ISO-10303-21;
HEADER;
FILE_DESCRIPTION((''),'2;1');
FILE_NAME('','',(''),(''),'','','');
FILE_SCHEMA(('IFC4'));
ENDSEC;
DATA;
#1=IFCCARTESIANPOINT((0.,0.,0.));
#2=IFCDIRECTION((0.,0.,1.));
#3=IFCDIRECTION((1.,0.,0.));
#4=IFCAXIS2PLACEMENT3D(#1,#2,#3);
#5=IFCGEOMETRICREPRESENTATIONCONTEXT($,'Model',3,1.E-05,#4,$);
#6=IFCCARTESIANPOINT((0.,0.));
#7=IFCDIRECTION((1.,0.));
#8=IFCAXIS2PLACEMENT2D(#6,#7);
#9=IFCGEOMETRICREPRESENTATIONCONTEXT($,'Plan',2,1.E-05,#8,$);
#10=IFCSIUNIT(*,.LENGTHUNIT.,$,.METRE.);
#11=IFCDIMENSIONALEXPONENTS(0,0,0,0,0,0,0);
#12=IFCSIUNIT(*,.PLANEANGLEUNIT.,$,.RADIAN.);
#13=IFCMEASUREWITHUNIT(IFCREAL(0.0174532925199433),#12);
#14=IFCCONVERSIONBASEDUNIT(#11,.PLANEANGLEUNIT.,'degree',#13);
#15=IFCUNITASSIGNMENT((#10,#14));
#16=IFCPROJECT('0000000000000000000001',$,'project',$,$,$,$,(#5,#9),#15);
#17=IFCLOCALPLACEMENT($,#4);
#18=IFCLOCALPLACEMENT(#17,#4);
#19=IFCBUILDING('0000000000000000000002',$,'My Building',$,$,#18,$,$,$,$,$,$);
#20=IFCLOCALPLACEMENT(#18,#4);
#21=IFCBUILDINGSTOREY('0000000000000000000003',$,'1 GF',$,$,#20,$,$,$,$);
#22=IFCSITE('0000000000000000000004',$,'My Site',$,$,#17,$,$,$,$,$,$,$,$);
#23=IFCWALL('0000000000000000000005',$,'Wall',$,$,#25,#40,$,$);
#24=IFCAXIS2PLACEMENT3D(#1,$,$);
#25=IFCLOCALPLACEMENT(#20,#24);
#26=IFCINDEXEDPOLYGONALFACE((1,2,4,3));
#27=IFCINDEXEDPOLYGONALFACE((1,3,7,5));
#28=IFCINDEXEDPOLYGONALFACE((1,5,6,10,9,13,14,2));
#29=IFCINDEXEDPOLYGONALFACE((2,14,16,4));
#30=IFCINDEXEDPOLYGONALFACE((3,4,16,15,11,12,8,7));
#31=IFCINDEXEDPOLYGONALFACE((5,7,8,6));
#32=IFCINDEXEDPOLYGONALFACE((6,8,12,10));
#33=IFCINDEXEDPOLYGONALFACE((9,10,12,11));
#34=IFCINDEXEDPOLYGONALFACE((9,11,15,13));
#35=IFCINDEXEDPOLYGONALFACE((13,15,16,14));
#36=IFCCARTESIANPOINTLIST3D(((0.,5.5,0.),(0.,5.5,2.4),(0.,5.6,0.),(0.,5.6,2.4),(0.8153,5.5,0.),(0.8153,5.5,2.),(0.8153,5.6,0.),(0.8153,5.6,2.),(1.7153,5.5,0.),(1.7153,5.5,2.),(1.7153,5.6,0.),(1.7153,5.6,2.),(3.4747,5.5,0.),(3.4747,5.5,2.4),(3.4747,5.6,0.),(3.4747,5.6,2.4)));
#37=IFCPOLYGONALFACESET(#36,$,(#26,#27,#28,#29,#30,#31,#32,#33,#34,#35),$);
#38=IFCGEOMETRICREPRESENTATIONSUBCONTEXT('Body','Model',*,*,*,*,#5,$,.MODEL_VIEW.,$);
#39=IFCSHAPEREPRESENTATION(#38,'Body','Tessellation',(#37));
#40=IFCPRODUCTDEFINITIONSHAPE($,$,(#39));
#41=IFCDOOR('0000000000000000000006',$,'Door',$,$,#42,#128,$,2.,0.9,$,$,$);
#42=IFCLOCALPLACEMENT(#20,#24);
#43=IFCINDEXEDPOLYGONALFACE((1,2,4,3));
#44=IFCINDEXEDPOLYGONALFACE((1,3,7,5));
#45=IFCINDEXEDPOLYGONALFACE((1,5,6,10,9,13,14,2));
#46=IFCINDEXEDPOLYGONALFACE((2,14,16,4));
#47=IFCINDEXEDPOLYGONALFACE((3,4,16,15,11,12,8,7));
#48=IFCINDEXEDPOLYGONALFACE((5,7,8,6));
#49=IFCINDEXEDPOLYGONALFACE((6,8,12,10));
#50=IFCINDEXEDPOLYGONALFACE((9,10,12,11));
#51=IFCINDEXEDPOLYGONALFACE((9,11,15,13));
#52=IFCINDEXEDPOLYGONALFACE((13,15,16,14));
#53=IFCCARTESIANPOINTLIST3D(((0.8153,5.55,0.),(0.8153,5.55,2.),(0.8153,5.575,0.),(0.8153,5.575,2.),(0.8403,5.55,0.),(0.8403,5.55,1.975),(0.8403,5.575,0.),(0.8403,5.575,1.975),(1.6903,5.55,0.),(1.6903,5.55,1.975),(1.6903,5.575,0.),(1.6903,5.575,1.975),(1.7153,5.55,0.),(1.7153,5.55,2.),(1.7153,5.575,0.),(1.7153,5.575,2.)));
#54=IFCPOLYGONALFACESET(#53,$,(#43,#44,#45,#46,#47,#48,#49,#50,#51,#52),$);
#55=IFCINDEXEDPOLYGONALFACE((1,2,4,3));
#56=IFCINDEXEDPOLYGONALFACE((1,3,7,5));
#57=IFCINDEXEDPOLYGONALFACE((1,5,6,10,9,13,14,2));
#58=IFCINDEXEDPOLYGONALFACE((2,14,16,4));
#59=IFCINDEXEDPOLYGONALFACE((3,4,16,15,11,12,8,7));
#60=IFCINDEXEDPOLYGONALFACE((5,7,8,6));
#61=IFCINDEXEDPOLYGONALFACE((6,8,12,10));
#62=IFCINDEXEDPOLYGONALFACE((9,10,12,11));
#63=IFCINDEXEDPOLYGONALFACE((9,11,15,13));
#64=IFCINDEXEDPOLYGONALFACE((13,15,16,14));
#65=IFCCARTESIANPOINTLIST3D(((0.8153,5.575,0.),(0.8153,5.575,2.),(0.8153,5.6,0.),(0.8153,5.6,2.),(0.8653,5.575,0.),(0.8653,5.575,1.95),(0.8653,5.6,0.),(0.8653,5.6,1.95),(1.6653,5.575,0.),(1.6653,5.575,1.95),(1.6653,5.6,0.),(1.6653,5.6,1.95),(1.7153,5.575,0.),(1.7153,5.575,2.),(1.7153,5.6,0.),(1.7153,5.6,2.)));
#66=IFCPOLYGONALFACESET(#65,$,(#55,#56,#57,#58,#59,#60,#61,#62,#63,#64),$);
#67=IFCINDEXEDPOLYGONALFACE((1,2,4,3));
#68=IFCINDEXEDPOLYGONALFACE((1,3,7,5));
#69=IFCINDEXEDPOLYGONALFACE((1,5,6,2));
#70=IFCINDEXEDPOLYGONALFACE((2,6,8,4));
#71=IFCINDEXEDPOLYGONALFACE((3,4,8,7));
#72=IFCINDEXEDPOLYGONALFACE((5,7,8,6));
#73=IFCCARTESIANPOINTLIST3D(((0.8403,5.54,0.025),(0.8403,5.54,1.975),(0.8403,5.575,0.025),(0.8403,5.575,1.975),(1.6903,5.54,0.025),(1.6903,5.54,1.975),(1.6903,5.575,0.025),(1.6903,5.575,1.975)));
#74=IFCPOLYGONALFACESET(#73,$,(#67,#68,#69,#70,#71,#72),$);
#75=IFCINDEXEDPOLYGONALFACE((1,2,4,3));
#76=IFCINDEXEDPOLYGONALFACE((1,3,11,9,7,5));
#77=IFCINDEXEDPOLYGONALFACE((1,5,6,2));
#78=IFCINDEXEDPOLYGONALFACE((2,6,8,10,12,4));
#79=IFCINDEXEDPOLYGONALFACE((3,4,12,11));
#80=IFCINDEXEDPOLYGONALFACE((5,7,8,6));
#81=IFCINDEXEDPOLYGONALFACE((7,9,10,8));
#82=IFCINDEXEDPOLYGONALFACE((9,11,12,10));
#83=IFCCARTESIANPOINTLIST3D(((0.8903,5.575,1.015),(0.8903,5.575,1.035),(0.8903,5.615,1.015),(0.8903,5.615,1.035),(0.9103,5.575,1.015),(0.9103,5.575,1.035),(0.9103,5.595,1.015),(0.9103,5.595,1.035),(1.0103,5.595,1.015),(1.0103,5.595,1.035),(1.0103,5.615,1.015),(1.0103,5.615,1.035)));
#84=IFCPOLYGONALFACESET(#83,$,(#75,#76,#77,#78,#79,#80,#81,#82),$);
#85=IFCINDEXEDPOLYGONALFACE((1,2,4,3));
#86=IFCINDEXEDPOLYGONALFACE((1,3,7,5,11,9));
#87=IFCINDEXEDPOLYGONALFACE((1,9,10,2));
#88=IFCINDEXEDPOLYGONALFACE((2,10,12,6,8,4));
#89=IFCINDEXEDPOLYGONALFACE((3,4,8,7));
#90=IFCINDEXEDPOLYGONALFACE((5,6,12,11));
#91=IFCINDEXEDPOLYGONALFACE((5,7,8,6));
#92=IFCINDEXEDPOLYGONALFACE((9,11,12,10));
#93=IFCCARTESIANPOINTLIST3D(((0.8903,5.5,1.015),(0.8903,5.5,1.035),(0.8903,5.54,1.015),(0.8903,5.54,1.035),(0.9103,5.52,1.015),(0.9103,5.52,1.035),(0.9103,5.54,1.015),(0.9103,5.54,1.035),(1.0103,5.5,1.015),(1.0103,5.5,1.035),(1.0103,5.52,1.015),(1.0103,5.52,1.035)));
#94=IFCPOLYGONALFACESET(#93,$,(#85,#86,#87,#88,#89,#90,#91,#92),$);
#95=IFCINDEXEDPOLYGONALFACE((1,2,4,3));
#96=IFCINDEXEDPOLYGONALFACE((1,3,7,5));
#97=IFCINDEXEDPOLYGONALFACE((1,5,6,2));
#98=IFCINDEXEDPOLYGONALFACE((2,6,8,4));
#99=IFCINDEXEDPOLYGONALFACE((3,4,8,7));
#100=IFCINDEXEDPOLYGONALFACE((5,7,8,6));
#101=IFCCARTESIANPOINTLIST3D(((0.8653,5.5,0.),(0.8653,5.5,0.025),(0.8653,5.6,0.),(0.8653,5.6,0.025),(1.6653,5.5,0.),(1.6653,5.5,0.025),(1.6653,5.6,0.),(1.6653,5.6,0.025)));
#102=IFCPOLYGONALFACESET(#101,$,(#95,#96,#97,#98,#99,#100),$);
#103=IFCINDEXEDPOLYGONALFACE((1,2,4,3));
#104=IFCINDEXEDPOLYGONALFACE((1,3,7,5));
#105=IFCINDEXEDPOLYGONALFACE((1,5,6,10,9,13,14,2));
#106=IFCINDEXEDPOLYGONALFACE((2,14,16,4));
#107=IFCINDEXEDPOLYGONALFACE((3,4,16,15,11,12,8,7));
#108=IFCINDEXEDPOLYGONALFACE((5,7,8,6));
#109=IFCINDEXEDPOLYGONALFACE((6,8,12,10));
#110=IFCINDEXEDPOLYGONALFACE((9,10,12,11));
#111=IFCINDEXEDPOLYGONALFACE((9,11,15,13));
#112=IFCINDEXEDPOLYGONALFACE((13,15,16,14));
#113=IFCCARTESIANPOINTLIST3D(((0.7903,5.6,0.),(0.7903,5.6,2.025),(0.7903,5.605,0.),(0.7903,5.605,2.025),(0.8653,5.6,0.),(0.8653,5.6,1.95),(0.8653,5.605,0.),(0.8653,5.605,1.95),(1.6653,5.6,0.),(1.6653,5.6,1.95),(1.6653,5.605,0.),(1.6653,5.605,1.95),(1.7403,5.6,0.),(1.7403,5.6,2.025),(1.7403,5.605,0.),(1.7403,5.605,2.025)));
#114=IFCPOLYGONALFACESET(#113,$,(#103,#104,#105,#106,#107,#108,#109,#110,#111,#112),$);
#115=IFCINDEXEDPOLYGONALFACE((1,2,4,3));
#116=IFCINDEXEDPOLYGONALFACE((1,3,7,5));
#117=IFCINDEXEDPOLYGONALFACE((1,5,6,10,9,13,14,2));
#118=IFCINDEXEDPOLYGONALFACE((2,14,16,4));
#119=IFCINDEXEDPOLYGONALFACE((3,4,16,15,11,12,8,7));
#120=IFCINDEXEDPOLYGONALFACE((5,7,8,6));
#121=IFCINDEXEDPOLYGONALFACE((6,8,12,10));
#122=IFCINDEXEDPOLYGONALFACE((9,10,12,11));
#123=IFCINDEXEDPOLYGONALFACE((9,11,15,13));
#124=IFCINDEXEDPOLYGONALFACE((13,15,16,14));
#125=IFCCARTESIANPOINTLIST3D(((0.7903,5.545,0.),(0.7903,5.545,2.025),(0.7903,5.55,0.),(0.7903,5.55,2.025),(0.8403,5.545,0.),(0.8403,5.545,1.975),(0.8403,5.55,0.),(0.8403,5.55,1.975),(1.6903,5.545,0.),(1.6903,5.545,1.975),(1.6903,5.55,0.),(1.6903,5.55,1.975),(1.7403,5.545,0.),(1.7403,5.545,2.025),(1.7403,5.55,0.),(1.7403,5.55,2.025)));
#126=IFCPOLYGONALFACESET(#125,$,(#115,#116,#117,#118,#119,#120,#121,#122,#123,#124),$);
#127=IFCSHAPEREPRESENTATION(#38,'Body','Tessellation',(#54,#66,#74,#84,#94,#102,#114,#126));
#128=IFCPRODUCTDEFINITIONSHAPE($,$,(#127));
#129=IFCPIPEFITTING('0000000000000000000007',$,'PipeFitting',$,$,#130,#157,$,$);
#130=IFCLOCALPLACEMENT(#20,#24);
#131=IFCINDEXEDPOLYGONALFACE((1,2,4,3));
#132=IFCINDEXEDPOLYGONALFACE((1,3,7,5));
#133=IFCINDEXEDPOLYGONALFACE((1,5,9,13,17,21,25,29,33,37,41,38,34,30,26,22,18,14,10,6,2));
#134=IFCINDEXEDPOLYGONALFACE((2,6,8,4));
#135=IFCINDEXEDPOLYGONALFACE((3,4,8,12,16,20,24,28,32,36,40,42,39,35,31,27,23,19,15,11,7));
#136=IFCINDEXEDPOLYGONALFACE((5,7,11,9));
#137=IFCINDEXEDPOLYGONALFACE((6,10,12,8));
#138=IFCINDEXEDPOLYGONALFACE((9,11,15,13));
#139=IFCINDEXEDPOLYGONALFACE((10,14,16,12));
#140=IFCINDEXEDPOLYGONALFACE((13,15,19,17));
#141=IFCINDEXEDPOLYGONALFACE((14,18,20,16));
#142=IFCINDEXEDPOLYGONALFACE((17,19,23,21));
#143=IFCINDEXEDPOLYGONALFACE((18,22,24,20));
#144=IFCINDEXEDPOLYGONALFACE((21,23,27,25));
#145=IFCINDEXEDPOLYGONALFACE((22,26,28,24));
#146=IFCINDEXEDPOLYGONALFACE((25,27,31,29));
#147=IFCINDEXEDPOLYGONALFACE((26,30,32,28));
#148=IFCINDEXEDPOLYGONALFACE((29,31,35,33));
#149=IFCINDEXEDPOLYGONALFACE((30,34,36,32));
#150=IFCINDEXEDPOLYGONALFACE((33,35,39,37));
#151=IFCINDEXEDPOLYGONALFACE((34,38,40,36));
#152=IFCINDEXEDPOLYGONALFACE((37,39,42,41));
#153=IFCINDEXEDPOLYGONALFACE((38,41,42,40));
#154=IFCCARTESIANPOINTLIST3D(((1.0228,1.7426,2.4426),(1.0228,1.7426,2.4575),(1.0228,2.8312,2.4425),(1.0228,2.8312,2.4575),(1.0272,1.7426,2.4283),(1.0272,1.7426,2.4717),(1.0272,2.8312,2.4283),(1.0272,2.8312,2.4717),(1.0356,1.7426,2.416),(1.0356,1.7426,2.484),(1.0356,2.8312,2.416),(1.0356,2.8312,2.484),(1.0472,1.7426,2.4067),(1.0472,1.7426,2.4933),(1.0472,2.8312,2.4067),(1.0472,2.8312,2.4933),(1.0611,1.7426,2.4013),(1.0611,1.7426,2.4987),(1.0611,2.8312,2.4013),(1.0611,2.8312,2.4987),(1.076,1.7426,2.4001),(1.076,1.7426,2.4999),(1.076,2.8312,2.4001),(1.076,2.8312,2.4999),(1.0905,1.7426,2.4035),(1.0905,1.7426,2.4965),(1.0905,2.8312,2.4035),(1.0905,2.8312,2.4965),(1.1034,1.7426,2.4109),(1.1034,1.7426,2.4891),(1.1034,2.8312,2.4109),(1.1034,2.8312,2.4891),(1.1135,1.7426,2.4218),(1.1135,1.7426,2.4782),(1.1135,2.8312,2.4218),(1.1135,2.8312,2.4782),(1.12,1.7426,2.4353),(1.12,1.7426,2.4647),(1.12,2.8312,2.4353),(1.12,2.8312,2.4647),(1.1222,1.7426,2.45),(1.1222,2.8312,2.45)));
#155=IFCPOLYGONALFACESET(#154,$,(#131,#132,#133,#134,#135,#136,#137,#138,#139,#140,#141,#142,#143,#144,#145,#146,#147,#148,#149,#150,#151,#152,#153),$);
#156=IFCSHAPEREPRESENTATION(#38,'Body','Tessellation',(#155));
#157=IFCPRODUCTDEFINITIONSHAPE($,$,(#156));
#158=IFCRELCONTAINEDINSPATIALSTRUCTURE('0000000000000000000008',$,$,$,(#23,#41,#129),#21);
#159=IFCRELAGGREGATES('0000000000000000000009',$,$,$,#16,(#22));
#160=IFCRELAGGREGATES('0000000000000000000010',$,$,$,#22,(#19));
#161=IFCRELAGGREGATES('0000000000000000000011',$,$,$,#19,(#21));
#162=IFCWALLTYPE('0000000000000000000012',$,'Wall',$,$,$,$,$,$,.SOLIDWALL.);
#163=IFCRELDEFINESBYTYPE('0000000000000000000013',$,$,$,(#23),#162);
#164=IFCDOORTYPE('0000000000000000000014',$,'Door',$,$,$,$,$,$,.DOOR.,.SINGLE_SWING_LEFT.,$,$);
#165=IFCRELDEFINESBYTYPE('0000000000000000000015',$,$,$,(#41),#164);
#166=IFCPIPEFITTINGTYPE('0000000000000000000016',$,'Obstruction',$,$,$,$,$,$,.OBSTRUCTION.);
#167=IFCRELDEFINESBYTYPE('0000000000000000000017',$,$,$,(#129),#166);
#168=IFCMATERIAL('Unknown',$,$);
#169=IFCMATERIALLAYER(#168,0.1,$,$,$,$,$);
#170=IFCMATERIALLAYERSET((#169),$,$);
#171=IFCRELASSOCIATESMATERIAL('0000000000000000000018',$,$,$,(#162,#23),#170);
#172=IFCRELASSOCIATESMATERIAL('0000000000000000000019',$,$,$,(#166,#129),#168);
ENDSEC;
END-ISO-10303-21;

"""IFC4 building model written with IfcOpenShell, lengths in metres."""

from ifc_helpers import new_model, entity, si_unit, converted_unit, frame, origin_with_axes, origin_2d_with_axis, place, context, subcontext, project, spatial, line, indexed_curve, circle, outline, extrude, shape, source, transform, mapped, material, layer, layer_set, layer_usage, material_profile, profile_set, profile_usage, type_object, type_shapes, element, fill, save


model = new_model("IFC4")

# Units and contexts
model_context = context("Model", 3, precision=1e-05, world=origin_with_axes())
plan_context = context("Plan", 2, precision=1e-05, world=origin_2d_with_axis())
body_context_1 = subcontext(model_context, "Body", "Model", "MODEL_VIEW")
body_context_2 = subcontext(plan_context, "Body", "Plan", "PLAN_VIEW")
ifc_project = project(units=[si_unit("LENGTHUNIT", "METRE"), converted_unit("PLANEANGLEUNIT", "degree", entity("IfcReal", 0.0174532925199433), si_unit("PLANEANGLEUNIT", "RADIAN"), dimensions=[0, 0, 0, 0, 0, 0, 0])], contexts=[model_context, plan_context])

# Site, building, storey
site_placement = place(None, origin_with_axes())
site = spatial("IfcSite", under=ifc_project, at=site_placement, Name="My Site")
building_placement = place(site_placement, origin_with_axes())
building = spatial("IfcBuilding", under=site, at=building_placement, Name="My Building")
storey_placement = place(building_placement, origin_with_axes())
storey = spatial("IfcBuildingStorey", under=building, at=storey_placement, Name="1 GF")

# Shared definitions
ifc_material = material(Name="Unknown")

# Shared definitions
ifc_layer_1 = layer(ifc_material, 0.1)
ifc_layer_set_1 = layer_set([ifc_layer_1])
wall_type = type_object("IfcWallType", Name="Wall", PredefinedType="SOLIDWALL", material=ifc_layer_set_1)
shared_shape_1 = source(origin_with_axes(), body_context_1, "Body", "SweptSolid", [
    extrude(outline(indexed_curve([(0.0, 0.0), (0.9, 0.0), (0.9, 2.0), (0.0, 2.0)], segments=[line(1, 2, 3, 4, 1)])), frame((0.0, -0.6, 0.0), z_axis=(0.0, -1.0, 0.0), x_axis=(1.0, 0.0, 0.0)), (0.0, 0.0, -1.0), 1.2),
])
door_type = type_object("IfcDoorType", Name="Door", OperationType="SINGLE_SWING_LEFT", PredefinedType="DOOR")
shared_shape_2 = source(origin_with_axes(), body_context_1, "Body", "SweptSolid", [
    extrude(outline(indexed_curve([(0.0, 0.0), (0.0, 2.0), (0.9, 2.0), (0.9, 0.0), (0.875, 0.0), (0.875, 1.975), (0.025, 1.975), (0.025, 0.0)], segments=[line(1, 2, 3, 4, 5, 6, 7, 8, 1)])), frame((0.0, 0.025, 0.0), z_axis=(0.0, -1.0, 0.0), x_axis=(1.0, 0.0, 0.0)), (0.0, 0.0, -1.0), 0.025),
    extrude(outline(indexed_curve([(0.0, 0.0), (0.0, 2.0), (0.9, 2.0), (0.9, 0.0), (0.85, 0.0), (0.85, 1.95), (0.05, 1.95), (0.05, 0.0)], segments=[line(1, 2, 3, 4, 5, 6, 7, 8, 1)])), frame((0.0, 0.0, 0.0), z_axis=(0.0, -1.0, 0.0), x_axis=(1.0, 0.0, 0.0)), (0.0, 0.0, -1.0), 0.025),
    extrude(outline(indexed_curve([(0.0, 0.0), (0.85, 0.0), (0.85, 0.035), (0.0, 0.035)], segments=[line(1, 2, 3, 4, 1)])), frame((0.025, 0.025, 0.025), z_axis=(0.0, 0.0, 1.0), x_axis=(1.0, 0.0, 0.0)), (0.0, 0.0, 1.0), 1.95),
    extrude(outline(indexed_curve([(0.0, 0.0), (0.0, -0.04), (-0.12, -0.04), (-0.12, -0.02), (-0.02, -0.02), (-0.02, 0.0)], segments=[line(1, 2, 3, 4, 5, 6, 1)])), frame((0.825, 0.025, 1.015), z_axis=(0.0, 0.0, 1.0), x_axis=(1.0, 0.0, 0.0)), (0.0, 0.0, 1.0), 0.02),
    extrude(outline(indexed_curve([(0.0, 0.0), (0.0, 0.04), (-0.12, 0.04), (-0.12, 0.02), (-0.02, 0.02), (-0.02, 0.0)], segments=[line(1, 2, 3, 4, 5, 6, 1)])), frame((0.825, 0.06, 1.015), z_axis=(0.0, 0.0, 1.0), x_axis=(1.0, 0.0, 0.0)), (0.0, 0.0, 1.0), 0.02),
    extrude(outline(indexed_curve([(0.0, 0.0), (0.8, 0.0), (0.8, 0.1), (0.0, 0.1)], segments=[line(1, 2, 3, 4, 1)])), frame((0.05, 0.0, 0.0), z_axis=(0.0, 0.0, 1.0), x_axis=(1.0, 0.0, 0.0)), (0.0, 0.0, 1.0), 0.025),
    extrude(outline(indexed_curve([(0.0, 0.0), (0.0, 2.025), (0.95, 2.025), (0.95, 0.0), (0.875, 0.0), (0.875, 1.95), (0.075, 1.95), (0.075, 0.0)], segments=[line(1, 2, 3, 4, 5, 6, 7, 8, 1)])), frame((-0.025, -0.005, 0.0), z_axis=(0.0, -1.0, 0.0), x_axis=(1.0, 0.0, 0.0)), (0.0, 0.0, -1.0), 0.005),
    extrude(outline(indexed_curve([(0.0, 0.0), (0.0, 2.025), (0.95, 2.025), (0.95, 0.0), (0.9, 0.0), (0.9, 1.975), (0.05, 1.975), (0.05, 0.0)], segments=[line(1, 2, 3, 4, 5, 6, 7, 8, 1)])), frame((-0.025, 0.05, 0.0), z_axis=(0.0, -1.0, 0.0), x_axis=(1.0, 0.0, 0.0)), (0.0, 0.0, -1.0), 0.005),
])
shared_shape_3 = source(origin_with_axes(), body_context_2, "Body", "Curve2D", [
    entity("IfcIndexedPolyCurve", entity("IfcCartesianPointList2D", [[0.0, 0.0], [0.0, 0.05], [0.025, 0.05], [0.025, 0.025], [0.05, 0.025], [0.05, 0.0]]), [entity("IfcLineIndex", [1, 2, 3, 4, 5, 6, 1])]),
    entity("IfcIndexedPolyCurve", entity("IfcCartesianPointList2D", [[0.9, 0.0], [0.9, 0.05], [0.875, 0.05], [0.875, 0.025], [0.85, 0.025], [0.85, 0.0]]), [entity("IfcLineIndex", [1, 2, 3, 4, 5, 6, 1])]),
    entity("IfcTrimmedCurve", entity("IfcEllipse", entity("IfcAxis2Placement2D", entity("IfcCartesianPoint", [0.06, 0.05]), entity("IfcDirection", [1.0, 0.0])), 0.815, 0.85), [entity("IfcCartesianPoint", [0.875, 0.05])], [entity("IfcCartesianPoint", [0.06, 0.9])], True, "CARTESIAN"),
    entity("IfcIndexedPolyCurve", entity("IfcCartesianPointList2D", [[0.025, 0.05], [0.06, 0.05], [0.06, 0.9], [0.025, 0.9]]), [entity("IfcLineIndex", [1, 2, 3, 4, 1])]),
])
type_shapes(door_type, [shared_shape_2, shared_shape_3])

# Wall, opening, door
ifc_layer_usage_1 = layer_usage(ifc_layer_set_1, "AXIS2", "POSITIVE", 0.0)
wall_1_placement = place(storey_placement, frame((3.4747, 5.6, 0.0), z_axis=(0.0, 0.0, 1.0), x_axis=(-1.0, 0.0, 0.0)))
wall_1 = element("IfcWall", 1, at=wall_1_placement, inside=storey, type_object=wall_type, material=ifc_layer_usage_1, Name="Wall", context=body_context_1, shape_type="SweptSolid", body=[
    extrude(outline(indexed_curve([(0.0, 0.0), (0.0, 0.1), (3.4747, 0.1), (3.4747, 0.0)], segments=[line(1, 2, 3, 4, 1)])), origin_with_axes(), (0.0, 0.0, 1.0), 2.4),
])
opening_1_placement = place(wall_1_placement, frame((1.7594, 0.0, 0.0), z_axis=(0.0, 0.0, 1.0), x_axis=(1.0, 0.0, 0.0)))
opening_1 = element("IfcOpeningElement", 2, at=opening_1_placement, cuts=wall_1, PredefinedType="OPENING", context=body_context_1, shape_type="MappedRepresentation", body=[
    mapped(shared_shape_1, transform((0.0, 0.0, 0.0), x_axis=(1.0, 0.0, 0.0), y_axis=(0.0, 1.0, 0.0), z_axis=(0.0, 0.0, 1.0), scale=1.0)),
])
door_1_placement = place(opening_1_placement, frame((0.0, 0.0, 0.0), z_axis=(0.0, 0.0, 1.0), x_axis=(1.0, 0.0, 0.0)))
door_1 = element("IfcDoor", 3, at=door_1_placement, inside=storey, type_object=door_type, Name="Door", OverallHeight=2.0, OverallWidth=0.9, shapes=[
    shape(body_context_1, "Body", "MappedRepresentation", [mapped(shared_shape_2, transform((0.0, 0.0, 0.0), x_axis=(1.0, 0.0, 0.0), y_axis=(0.0, 1.0, 0.0), z_axis=(0.0, 0.0, 1.0), scale=1.0))]),
    shape(body_context_2, "Body", "MappedRepresentation", [mapped(shared_shape_3, transform((0.0, 0.0, 0.0), x_axis=(1.0, 0.0, 0.0), y_axis=(0.0, 1.0, 0.0), z_axis=(0.0, 0.0, 1.0), scale=1.0))]),
])
fill(opening_1, door_1)

# Pipe fitting
ifc_material_profile_1 = material_profile(ifc_material, circle(Radius=0.05))
ifc_profile_set_1 = profile_set([ifc_material_profile_1])
ifc_profile_usage_1 = profile_usage(ifc_profile_set_1, cardinal=5)
pipe_fitting_type = type_object("IfcPipeFittingType", Name="Obstruction", PredefinedType="OBSTRUCTION", material=ifc_profile_set_1)
pipe_fitting_1_placement = place(storey_placement, frame((1.0722, 2.8312, 2.45), z_axis=(0.0, -1.0, 0.000002), x_axis=(1.0, 0.0, 0.0)))
element("IfcPipeFitting", 4, at=pipe_fitting_1_placement, inside=storey, type_object=pipe_fitting_type, material=ifc_profile_usage_1, Name="PipeFitting", context=body_context_1, shape_type="SweptSolid", body=[
    extrude(circle(Radius=0.05), origin_with_axes(), (0.0, 0.0, 1.0), 1.0886),
])

save(model, "model.ifc")
